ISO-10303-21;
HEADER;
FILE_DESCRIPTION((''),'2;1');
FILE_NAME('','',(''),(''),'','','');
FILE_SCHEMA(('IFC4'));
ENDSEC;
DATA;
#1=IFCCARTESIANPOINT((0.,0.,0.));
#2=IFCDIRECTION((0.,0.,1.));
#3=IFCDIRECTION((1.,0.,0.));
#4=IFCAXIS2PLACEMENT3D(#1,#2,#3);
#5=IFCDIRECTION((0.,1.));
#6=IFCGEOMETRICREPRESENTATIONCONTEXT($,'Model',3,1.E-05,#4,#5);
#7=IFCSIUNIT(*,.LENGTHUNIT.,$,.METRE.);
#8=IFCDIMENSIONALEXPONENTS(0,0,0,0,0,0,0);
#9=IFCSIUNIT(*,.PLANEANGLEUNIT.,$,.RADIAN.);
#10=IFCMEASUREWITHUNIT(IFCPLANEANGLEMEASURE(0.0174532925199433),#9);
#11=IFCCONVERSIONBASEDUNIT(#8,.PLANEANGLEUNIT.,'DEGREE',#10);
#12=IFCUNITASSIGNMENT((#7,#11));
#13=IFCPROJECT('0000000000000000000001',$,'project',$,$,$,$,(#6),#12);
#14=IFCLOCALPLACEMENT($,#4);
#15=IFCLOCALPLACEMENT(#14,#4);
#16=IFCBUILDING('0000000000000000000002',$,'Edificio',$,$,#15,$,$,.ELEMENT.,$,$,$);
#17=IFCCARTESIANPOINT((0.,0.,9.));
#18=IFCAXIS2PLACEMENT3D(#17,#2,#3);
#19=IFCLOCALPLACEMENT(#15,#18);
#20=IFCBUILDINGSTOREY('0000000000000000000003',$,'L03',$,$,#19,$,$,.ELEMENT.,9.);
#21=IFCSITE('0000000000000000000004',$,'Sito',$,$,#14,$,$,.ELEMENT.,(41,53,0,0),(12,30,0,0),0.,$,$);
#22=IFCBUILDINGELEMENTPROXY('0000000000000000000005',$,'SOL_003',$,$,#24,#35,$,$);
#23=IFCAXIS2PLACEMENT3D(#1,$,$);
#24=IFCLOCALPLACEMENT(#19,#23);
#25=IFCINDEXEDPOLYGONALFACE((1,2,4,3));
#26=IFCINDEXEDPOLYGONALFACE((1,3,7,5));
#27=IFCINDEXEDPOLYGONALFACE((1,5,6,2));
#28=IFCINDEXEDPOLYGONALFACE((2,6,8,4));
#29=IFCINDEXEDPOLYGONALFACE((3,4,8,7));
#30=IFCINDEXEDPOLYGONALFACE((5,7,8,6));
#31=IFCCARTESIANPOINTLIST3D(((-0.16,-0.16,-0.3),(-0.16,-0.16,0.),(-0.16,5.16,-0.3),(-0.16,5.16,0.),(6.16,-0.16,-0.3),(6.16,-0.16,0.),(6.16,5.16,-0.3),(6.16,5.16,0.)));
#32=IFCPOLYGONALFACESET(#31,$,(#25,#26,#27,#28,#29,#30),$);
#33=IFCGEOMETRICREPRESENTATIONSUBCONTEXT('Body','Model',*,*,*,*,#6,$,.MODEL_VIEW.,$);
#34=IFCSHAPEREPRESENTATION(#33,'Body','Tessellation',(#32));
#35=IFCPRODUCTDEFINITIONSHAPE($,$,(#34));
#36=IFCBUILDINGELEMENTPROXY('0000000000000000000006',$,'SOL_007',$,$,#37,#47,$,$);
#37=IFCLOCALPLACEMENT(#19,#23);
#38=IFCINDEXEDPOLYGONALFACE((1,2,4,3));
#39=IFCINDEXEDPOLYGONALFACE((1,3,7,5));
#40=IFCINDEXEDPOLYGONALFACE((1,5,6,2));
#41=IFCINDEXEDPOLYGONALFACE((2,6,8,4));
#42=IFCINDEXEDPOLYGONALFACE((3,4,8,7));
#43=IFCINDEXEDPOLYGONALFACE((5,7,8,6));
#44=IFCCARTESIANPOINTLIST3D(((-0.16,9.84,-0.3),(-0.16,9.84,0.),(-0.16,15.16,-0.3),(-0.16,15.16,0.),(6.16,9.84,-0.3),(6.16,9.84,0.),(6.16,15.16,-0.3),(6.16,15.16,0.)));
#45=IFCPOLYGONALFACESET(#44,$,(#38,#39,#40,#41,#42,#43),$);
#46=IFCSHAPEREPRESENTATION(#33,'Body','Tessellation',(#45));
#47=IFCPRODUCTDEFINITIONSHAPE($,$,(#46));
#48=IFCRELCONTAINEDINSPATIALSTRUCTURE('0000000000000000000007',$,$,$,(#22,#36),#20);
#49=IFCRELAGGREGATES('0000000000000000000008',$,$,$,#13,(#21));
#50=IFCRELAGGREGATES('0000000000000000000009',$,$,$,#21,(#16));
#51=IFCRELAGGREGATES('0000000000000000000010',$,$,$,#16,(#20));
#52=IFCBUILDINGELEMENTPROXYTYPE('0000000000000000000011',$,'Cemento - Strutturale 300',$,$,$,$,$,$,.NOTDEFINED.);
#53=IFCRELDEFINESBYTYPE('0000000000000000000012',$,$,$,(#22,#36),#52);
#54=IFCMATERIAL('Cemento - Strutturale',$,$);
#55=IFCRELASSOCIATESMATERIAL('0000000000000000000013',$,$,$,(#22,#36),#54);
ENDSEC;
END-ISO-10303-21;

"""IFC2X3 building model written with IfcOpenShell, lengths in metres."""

from ifc_helpers import new_model, entity, si_unit, converted_unit, direction, frame, origin_with_axes, place, context, subcontext, project, spatial, polyline, outline, extrude, material, type_object, element, save


model = new_model("IFC2X3")

# Units and contexts
model_context = context("Model", 3, precision=1e-05, world=origin_with_axes(), true_north=direction((0.0, 1.0)))
body_context = subcontext(model_context, "Body", "Model", "MODEL_VIEW")
ifc_project = project(units=[si_unit("LENGTHUNIT", "METRE"), converted_unit("PLANEANGLEUNIT", "DEGREE", entity("IfcPlaneAngleMeasure", 0.0174532925199433), si_unit("PLANEANGLEUNIT", "RADIAN"), dimensions=[0, 0, 0, 0, 0, 0, 0])], contexts=[model_context])

# Site, building, storey
site_placement = place(None, origin_with_axes())
site = spatial("IfcSite", under=ifc_project, at=site_placement, Name="Sito", CompositionType="ELEMENT", RefLatitude=(41, 53, 0, 0), RefLongitude=(12, 30, 0, 0), RefElevation=0.0)
building_placement = place(site_placement, origin_with_axes())
building = spatial("IfcBuilding", under=site, at=building_placement, Name="Edificio", CompositionType="ELEMENT")
storey_placement = place(building_placement, frame((0.0, 0.0, 9.0), z_axis=(0.0, 0.0, 1.0), x_axis=(1.0, 0.0, 0.0)))
storey = spatial("IfcBuildingStorey", under=building, at=storey_placement, Name="L03", CompositionType="ELEMENT", Elevation=9.0)

# Building element proxies
ifc_material = material(Name="Cemento - Strutturale")
building_element_proxy_type = type_object("IfcBuildingElementProxyType", Name="Cemento - Strutturale 300", PredefinedType="NOTDEFINED")
for number, where, z_axis, x_axis, name in (
    (1, (-0.16, -0.16, 0.0), (0.0, 0.0, 1.0), (1.0, 0.0, 0.0), "SOL_003"),
    (2, (-0.16, 9.84, 0.0), (0.0, 0.0, 1.0), (1.0, 0.0, 0.0), "SOL_007"),
):
    element("IfcBuildingElementProxy", number, at=place(storey_placement, frame(where, z_axis=z_axis, x_axis=x_axis)), inside=storey, type_object=building_element_proxy_type, material=ifc_material, Name=name, context=body_context, shape_type="SweptSolid", body=[
        extrude(outline(polyline([(0.0, 0.0), (6.32, 0.0), (6.32, 5.32), (0.0, 5.32), (0.0, 0.0)])), frame((0.0, 0.0, -0.3), z_axis=(0.0, 0.0, 1.0), x_axis=(1.0, 0.0, 0.0)), (0.0, 0.0, 1.0), 0.3),
    ])

save(model, "model.ifc")
